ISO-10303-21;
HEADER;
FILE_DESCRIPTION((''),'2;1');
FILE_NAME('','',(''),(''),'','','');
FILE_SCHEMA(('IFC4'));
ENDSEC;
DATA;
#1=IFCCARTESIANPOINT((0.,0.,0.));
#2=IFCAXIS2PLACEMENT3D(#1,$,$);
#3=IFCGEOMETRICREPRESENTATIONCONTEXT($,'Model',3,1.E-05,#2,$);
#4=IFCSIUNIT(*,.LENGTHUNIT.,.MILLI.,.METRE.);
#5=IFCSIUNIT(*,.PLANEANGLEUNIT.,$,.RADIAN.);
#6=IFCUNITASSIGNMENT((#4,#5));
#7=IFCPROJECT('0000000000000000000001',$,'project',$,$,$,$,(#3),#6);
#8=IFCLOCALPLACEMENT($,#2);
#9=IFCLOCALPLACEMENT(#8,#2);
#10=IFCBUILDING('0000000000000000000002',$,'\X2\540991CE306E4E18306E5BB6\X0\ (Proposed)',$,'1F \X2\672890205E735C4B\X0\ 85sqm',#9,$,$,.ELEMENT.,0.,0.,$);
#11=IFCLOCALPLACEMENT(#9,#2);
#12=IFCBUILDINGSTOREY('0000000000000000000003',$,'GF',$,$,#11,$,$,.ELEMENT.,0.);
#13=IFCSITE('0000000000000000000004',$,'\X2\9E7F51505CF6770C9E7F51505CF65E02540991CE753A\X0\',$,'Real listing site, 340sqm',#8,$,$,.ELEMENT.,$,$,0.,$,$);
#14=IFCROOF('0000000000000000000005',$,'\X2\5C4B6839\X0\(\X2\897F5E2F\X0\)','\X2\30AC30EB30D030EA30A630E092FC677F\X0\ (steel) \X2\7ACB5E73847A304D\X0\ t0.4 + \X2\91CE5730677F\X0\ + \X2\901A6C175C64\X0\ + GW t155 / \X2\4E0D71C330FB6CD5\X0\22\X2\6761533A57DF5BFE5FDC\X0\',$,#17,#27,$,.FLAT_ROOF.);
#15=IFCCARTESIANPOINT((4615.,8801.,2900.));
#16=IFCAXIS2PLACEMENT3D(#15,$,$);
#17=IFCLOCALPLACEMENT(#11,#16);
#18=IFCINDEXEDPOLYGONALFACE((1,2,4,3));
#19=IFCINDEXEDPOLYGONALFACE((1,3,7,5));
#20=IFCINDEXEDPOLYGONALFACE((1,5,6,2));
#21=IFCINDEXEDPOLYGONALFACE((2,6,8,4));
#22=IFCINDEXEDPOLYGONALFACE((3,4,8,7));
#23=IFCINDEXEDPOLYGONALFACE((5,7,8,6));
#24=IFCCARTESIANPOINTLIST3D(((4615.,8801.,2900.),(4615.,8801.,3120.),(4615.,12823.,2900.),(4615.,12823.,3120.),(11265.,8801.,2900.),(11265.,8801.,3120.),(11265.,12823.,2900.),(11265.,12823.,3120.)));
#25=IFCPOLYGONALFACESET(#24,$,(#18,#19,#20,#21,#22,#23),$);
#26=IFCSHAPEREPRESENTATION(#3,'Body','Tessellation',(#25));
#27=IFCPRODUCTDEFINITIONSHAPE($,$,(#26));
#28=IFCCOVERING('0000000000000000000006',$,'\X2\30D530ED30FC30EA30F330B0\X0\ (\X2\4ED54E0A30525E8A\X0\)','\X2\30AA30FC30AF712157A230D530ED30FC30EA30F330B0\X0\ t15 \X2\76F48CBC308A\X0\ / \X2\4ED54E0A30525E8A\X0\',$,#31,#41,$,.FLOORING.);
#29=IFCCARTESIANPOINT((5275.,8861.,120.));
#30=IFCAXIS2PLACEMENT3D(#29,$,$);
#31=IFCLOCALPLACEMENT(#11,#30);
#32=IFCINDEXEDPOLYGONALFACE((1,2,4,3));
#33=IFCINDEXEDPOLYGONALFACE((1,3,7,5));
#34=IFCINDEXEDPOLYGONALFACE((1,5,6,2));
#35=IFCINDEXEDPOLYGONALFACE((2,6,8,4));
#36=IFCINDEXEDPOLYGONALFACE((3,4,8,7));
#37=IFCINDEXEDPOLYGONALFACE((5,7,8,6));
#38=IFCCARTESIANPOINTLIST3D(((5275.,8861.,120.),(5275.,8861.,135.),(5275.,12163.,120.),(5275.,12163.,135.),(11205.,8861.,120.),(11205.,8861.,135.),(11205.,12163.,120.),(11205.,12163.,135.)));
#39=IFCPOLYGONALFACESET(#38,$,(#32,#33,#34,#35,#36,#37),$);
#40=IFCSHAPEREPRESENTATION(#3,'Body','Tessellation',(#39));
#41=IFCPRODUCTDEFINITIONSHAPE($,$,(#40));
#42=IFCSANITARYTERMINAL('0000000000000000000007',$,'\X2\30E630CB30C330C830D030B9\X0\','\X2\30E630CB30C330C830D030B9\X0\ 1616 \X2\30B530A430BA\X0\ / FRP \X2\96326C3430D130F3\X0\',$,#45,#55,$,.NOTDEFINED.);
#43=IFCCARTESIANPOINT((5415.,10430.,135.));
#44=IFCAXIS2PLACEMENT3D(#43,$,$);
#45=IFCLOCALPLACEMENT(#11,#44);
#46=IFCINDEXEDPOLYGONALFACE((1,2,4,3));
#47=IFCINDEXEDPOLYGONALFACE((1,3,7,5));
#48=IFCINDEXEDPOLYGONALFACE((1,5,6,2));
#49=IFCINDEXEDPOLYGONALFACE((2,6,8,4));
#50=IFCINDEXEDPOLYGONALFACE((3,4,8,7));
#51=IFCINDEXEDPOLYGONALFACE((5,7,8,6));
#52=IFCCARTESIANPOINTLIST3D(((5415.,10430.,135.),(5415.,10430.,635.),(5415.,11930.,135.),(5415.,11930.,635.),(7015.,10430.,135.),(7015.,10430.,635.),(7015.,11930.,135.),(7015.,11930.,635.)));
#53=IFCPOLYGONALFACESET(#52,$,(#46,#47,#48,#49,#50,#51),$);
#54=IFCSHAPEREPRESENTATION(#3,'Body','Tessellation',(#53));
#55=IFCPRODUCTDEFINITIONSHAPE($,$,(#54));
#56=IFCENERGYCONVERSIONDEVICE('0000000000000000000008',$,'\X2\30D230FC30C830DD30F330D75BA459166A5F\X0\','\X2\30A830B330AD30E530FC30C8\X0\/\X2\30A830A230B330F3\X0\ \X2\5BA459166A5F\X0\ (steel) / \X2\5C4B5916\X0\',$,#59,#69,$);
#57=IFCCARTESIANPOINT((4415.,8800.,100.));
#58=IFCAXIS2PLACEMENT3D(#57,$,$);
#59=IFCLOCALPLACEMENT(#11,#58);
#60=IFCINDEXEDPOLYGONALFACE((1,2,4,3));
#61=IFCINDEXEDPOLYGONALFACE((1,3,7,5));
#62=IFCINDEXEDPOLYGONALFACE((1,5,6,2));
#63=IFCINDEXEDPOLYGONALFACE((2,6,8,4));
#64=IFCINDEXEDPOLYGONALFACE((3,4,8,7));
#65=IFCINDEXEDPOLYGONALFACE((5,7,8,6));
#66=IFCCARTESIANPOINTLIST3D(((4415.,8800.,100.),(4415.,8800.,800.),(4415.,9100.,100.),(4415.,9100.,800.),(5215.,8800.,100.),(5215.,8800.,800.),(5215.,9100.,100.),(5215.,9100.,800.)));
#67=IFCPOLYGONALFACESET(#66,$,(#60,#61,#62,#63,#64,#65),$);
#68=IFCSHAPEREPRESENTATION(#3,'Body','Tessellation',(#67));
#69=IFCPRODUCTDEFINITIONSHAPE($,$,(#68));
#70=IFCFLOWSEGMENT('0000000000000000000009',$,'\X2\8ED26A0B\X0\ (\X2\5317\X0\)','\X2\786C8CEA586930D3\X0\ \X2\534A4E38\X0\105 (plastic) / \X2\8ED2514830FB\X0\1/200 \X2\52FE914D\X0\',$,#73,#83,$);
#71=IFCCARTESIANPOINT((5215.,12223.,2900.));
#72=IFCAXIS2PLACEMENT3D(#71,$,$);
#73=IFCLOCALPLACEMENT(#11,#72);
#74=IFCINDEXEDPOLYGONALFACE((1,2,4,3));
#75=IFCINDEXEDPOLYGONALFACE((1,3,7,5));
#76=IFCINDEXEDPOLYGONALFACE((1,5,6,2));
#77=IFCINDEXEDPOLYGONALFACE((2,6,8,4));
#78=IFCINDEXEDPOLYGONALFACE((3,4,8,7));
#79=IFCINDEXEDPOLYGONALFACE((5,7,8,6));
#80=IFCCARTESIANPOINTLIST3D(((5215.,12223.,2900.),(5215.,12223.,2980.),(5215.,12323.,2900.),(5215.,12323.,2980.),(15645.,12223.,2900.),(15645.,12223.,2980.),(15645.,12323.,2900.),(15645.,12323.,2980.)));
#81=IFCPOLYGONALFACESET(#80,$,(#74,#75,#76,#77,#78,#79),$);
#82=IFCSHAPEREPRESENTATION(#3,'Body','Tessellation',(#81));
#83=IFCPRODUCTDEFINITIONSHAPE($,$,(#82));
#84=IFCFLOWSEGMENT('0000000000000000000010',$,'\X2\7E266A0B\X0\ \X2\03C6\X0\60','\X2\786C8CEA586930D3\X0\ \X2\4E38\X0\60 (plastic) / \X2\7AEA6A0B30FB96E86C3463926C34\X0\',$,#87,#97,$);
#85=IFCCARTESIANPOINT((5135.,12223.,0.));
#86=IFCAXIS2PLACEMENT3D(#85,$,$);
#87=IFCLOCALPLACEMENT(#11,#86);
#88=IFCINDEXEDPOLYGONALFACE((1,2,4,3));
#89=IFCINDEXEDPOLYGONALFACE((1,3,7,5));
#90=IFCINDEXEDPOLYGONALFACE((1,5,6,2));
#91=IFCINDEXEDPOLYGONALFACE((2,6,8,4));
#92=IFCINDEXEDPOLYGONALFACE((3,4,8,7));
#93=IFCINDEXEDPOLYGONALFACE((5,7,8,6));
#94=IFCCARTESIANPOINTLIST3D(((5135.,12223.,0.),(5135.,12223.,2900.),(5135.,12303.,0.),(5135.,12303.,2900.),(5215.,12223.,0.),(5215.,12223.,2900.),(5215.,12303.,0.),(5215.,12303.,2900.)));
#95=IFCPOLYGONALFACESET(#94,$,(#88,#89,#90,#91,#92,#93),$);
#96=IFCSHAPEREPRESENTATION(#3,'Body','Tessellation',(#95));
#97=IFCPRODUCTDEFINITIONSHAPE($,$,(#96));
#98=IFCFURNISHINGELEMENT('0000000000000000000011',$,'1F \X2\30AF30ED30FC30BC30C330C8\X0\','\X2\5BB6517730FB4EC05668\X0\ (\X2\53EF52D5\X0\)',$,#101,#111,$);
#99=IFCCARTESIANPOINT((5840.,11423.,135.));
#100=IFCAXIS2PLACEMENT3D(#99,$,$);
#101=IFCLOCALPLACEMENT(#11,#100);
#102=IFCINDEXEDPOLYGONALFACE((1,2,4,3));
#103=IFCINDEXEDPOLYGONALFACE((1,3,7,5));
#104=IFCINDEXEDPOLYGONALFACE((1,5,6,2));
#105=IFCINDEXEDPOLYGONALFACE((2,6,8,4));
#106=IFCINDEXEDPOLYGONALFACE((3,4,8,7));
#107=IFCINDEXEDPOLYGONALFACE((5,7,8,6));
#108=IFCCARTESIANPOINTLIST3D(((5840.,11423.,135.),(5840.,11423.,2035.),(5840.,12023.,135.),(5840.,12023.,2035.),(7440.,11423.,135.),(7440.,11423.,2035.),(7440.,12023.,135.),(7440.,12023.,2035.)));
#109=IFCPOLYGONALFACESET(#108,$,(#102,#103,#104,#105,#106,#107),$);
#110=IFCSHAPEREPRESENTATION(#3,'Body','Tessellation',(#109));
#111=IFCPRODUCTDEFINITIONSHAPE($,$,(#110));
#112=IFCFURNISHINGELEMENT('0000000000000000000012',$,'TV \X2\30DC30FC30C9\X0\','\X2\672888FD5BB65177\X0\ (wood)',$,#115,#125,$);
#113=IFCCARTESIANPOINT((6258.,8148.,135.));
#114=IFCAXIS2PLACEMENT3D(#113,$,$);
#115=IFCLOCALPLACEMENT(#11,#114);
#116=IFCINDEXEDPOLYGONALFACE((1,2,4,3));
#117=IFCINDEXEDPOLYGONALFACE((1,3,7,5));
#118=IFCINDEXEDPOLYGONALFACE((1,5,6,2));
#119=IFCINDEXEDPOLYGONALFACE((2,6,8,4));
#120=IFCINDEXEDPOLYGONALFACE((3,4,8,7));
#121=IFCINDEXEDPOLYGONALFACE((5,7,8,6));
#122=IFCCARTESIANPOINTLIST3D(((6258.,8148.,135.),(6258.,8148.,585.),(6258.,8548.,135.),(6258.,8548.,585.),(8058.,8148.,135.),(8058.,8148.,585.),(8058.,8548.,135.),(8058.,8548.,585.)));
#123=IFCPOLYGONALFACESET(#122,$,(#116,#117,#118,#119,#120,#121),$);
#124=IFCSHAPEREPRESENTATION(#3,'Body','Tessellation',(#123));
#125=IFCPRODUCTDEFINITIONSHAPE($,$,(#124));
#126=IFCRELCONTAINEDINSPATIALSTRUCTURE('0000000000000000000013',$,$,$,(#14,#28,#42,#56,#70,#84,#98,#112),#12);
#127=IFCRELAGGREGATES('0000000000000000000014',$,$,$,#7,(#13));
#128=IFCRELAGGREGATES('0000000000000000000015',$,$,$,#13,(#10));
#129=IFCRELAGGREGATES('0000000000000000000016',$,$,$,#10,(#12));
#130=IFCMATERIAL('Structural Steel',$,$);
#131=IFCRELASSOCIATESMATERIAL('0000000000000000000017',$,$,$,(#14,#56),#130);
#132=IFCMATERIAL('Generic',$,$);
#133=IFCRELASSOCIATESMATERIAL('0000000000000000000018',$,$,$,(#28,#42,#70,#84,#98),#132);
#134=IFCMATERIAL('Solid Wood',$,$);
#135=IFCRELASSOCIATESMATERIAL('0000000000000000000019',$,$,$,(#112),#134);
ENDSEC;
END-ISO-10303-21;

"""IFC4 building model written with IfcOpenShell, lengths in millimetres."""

from ifc_helpers import new_model, si_unit, frame, frame_2d, origin, place, context, project, spatial, rectangle, extrude, material, element, save


model = new_model("IFC4")

# Units and contexts
model_context = context("Model", 3, precision=1e-05, world=origin())
ifc_project = project(units=[si_unit("LENGTHUNIT", "METRE", prefix="MILLI"), si_unit("PLANEANGLEUNIT", "RADIAN")], contexts=[model_context])

# Site, building, storey
site_placement = place(None, origin())
site = spatial("IfcSite", under=ifc_project, at=site_placement, Name="鹿児島県鹿児島市吉野町", ObjectType="Real listing site, 340sqm", CompositionType="ELEMENT", RefElevation=0.0)
building_placement = place(site_placement, origin())
building = spatial("IfcBuilding", under=site, at=building_placement, Name="吉野の丘の家 (Proposed)", ObjectType="1F 木造平屋 85sqm", CompositionType="ELEMENT", ElevationOfRefHeight=0.0, ElevationOfTerrain=0.0)
storey_placement = place(building_placement, origin())
storey = spatial("IfcBuildingStorey", under=building, at=storey_placement, Name="GF", CompositionType="ELEMENT", Elevation=0.0)

# Shared definitions
ifc_material_1 = material(Name="Solid Wood")

# Roof
ifc_material_2 = material(Name="Structural Steel")
roof_placement = place(storey_placement, frame((4615.0, 8801.0, 2900.0)))
element("IfcRoof", 1, at=roof_placement, inside=storey, material=ifc_material_2, Name="屋根(西帯)", Description="ガルバリウム鋼板 (steel) 立平葺き t0.4 + 野地板 + 通気層 + GW t155 / 不燃・法22条区域対応", PredefinedType="FLAT_ROOF", context=model_context, shape_type="SweptSolid", body=[
    extrude(rectangle(XDim=6650.0, YDim=4022.0, at=frame_2d((3325.0, 2011.0))), frame((4615.0, 8801.0, 2900.0)), (0.0, 0.0, 1.0), 220.0),
])

# Covering
ifc_material_3 = material(Name="Generic")
covering_placement = place(storey_placement, frame((5275.0, 8861.0, 120.0)))
element("IfcCovering", 2, at=covering_placement, inside=storey, material=ifc_material_3, Name="フローリング (仕上げ床)", Description="オーク無垢フローリング t15 直貼り / 仕上げ床", PredefinedType="FLOORING", context=model_context, shape_type="SweptSolid", body=[
    extrude(rectangle(XDim=5930.0, YDim=3302.0, at=frame_2d((2965.0, 1651.0))), frame((5275.0, 8861.0, 120.0)), (0.0, 0.0, 1.0), 15.0),
])

# Sanitary terminal
sanitary_terminal_placement = place(storey_placement, frame((5415.0, 10430.0, 135.0)))
element("IfcSanitaryTerminal", 3, at=sanitary_terminal_placement, inside=storey, material=ifc_material_3, Name="ユニットバス", Description="ユニットバス 1616 サイズ / FRP 防水パン", PredefinedType="NOTDEFINED", context=model_context, shape_type="SweptSolid", body=[
    extrude(rectangle(XDim=1600.0, YDim=1500.0, at=frame_2d((800.0, 750.0))), frame((5415.0, 10430.0, 135.0)), (0.0, 0.0, 1.0), 500.0),
])

# Energy conversion device
energy_conversion_device_placement = place(storey_placement, frame((4415.0, 8800.0, 100.0)))
element("IfcEnergyConversionDevice", 4, at=energy_conversion_device_placement, inside=storey, material=ifc_material_2, Name="ヒートポンプ室外機", Description="エコキュート/エアコン 室外機 (steel) / 屋外", context=model_context, shape_type="SweptSolid", body=[
    extrude(rectangle(XDim=800.0, YDim=300.0, at=frame_2d((400.0, 150.0))), frame((4415.0, 8800.0, 100.0)), (0.0, 0.0, 1.0), 700.0),
])

# Flow segments
flow_segment_1_placement = place(storey_placement, frame((5215.0, 12223.0, 2900.0)))
element("IfcFlowSegment", 5, at=flow_segment_1_placement, inside=storey, material=ifc_material_3, Name="軒樋 (北)", Description="硬質塩ビ 半丸105 (plastic) / 軒先・1/200 勾配", context=model_context, shape_type="SweptSolid", body=[
    extrude(rectangle(XDim=10430.0, YDim=100.0, at=frame_2d((5215.0, 50.0))), frame((5215.0, 12223.0, 2900.0)), (0.0, 0.0, 1.0), 80.0),
])
flow_segment_2_placement = place(storey_placement, frame((5135.0, 12223.0, 0.0)))
element("IfcFlowSegment", 6, at=flow_segment_2_placement, inside=storey, material=ifc_material_3, Name="縦樋 φ60", Description="硬質塩ビ 丸60 (plastic) / 竪樋・雨水排水", context=model_context, shape_type="SweptSolid", body=[
    extrude(rectangle(XDim=80.0, YDim=80.0, at=frame_2d((40.0, 40.0))), frame((5135.0, 12223.0, 0.0)), (0.0, 0.0, 1.0), 2900.0),
])

# Furnishing elements
furnishing_1_placement = place(storey_placement, frame((5840.0, 11423.0, 135.0)))
element("IfcFurnishingElement", 7, at=furnishing_1_placement, inside=storey, material=ifc_material_3, Name="1F クローゼット", Description="家具・什器 (可動)", context=model_context, shape_type="SweptSolid", body=[
    extrude(rectangle(XDim=1600.0, YDim=600.0, at=frame_2d((800.0, 300.0))), frame((5840.0, 11423.0, 135.0)), (0.0, 0.0, 1.0), 1900.0),
])
furnishing_2_placement = place(storey_placement, frame((6258.0, 8148.0, 135.0)))
element("IfcFurnishingElement", 8, at=furnishing_2_placement, inside=storey, material=ifc_material_1, Name="TV ボード", Description="木製家具 (wood)", context=model_context, shape_type="SweptSolid", body=[
    extrude(rectangle(XDim=1800.0, YDim=400.0, at=frame_2d((900.0, 200.0))), frame((6258.0, 8148.0, 135.0)), (0.0, 0.0, 1.0), 450.0),
])

save(model, "model.ifc")
